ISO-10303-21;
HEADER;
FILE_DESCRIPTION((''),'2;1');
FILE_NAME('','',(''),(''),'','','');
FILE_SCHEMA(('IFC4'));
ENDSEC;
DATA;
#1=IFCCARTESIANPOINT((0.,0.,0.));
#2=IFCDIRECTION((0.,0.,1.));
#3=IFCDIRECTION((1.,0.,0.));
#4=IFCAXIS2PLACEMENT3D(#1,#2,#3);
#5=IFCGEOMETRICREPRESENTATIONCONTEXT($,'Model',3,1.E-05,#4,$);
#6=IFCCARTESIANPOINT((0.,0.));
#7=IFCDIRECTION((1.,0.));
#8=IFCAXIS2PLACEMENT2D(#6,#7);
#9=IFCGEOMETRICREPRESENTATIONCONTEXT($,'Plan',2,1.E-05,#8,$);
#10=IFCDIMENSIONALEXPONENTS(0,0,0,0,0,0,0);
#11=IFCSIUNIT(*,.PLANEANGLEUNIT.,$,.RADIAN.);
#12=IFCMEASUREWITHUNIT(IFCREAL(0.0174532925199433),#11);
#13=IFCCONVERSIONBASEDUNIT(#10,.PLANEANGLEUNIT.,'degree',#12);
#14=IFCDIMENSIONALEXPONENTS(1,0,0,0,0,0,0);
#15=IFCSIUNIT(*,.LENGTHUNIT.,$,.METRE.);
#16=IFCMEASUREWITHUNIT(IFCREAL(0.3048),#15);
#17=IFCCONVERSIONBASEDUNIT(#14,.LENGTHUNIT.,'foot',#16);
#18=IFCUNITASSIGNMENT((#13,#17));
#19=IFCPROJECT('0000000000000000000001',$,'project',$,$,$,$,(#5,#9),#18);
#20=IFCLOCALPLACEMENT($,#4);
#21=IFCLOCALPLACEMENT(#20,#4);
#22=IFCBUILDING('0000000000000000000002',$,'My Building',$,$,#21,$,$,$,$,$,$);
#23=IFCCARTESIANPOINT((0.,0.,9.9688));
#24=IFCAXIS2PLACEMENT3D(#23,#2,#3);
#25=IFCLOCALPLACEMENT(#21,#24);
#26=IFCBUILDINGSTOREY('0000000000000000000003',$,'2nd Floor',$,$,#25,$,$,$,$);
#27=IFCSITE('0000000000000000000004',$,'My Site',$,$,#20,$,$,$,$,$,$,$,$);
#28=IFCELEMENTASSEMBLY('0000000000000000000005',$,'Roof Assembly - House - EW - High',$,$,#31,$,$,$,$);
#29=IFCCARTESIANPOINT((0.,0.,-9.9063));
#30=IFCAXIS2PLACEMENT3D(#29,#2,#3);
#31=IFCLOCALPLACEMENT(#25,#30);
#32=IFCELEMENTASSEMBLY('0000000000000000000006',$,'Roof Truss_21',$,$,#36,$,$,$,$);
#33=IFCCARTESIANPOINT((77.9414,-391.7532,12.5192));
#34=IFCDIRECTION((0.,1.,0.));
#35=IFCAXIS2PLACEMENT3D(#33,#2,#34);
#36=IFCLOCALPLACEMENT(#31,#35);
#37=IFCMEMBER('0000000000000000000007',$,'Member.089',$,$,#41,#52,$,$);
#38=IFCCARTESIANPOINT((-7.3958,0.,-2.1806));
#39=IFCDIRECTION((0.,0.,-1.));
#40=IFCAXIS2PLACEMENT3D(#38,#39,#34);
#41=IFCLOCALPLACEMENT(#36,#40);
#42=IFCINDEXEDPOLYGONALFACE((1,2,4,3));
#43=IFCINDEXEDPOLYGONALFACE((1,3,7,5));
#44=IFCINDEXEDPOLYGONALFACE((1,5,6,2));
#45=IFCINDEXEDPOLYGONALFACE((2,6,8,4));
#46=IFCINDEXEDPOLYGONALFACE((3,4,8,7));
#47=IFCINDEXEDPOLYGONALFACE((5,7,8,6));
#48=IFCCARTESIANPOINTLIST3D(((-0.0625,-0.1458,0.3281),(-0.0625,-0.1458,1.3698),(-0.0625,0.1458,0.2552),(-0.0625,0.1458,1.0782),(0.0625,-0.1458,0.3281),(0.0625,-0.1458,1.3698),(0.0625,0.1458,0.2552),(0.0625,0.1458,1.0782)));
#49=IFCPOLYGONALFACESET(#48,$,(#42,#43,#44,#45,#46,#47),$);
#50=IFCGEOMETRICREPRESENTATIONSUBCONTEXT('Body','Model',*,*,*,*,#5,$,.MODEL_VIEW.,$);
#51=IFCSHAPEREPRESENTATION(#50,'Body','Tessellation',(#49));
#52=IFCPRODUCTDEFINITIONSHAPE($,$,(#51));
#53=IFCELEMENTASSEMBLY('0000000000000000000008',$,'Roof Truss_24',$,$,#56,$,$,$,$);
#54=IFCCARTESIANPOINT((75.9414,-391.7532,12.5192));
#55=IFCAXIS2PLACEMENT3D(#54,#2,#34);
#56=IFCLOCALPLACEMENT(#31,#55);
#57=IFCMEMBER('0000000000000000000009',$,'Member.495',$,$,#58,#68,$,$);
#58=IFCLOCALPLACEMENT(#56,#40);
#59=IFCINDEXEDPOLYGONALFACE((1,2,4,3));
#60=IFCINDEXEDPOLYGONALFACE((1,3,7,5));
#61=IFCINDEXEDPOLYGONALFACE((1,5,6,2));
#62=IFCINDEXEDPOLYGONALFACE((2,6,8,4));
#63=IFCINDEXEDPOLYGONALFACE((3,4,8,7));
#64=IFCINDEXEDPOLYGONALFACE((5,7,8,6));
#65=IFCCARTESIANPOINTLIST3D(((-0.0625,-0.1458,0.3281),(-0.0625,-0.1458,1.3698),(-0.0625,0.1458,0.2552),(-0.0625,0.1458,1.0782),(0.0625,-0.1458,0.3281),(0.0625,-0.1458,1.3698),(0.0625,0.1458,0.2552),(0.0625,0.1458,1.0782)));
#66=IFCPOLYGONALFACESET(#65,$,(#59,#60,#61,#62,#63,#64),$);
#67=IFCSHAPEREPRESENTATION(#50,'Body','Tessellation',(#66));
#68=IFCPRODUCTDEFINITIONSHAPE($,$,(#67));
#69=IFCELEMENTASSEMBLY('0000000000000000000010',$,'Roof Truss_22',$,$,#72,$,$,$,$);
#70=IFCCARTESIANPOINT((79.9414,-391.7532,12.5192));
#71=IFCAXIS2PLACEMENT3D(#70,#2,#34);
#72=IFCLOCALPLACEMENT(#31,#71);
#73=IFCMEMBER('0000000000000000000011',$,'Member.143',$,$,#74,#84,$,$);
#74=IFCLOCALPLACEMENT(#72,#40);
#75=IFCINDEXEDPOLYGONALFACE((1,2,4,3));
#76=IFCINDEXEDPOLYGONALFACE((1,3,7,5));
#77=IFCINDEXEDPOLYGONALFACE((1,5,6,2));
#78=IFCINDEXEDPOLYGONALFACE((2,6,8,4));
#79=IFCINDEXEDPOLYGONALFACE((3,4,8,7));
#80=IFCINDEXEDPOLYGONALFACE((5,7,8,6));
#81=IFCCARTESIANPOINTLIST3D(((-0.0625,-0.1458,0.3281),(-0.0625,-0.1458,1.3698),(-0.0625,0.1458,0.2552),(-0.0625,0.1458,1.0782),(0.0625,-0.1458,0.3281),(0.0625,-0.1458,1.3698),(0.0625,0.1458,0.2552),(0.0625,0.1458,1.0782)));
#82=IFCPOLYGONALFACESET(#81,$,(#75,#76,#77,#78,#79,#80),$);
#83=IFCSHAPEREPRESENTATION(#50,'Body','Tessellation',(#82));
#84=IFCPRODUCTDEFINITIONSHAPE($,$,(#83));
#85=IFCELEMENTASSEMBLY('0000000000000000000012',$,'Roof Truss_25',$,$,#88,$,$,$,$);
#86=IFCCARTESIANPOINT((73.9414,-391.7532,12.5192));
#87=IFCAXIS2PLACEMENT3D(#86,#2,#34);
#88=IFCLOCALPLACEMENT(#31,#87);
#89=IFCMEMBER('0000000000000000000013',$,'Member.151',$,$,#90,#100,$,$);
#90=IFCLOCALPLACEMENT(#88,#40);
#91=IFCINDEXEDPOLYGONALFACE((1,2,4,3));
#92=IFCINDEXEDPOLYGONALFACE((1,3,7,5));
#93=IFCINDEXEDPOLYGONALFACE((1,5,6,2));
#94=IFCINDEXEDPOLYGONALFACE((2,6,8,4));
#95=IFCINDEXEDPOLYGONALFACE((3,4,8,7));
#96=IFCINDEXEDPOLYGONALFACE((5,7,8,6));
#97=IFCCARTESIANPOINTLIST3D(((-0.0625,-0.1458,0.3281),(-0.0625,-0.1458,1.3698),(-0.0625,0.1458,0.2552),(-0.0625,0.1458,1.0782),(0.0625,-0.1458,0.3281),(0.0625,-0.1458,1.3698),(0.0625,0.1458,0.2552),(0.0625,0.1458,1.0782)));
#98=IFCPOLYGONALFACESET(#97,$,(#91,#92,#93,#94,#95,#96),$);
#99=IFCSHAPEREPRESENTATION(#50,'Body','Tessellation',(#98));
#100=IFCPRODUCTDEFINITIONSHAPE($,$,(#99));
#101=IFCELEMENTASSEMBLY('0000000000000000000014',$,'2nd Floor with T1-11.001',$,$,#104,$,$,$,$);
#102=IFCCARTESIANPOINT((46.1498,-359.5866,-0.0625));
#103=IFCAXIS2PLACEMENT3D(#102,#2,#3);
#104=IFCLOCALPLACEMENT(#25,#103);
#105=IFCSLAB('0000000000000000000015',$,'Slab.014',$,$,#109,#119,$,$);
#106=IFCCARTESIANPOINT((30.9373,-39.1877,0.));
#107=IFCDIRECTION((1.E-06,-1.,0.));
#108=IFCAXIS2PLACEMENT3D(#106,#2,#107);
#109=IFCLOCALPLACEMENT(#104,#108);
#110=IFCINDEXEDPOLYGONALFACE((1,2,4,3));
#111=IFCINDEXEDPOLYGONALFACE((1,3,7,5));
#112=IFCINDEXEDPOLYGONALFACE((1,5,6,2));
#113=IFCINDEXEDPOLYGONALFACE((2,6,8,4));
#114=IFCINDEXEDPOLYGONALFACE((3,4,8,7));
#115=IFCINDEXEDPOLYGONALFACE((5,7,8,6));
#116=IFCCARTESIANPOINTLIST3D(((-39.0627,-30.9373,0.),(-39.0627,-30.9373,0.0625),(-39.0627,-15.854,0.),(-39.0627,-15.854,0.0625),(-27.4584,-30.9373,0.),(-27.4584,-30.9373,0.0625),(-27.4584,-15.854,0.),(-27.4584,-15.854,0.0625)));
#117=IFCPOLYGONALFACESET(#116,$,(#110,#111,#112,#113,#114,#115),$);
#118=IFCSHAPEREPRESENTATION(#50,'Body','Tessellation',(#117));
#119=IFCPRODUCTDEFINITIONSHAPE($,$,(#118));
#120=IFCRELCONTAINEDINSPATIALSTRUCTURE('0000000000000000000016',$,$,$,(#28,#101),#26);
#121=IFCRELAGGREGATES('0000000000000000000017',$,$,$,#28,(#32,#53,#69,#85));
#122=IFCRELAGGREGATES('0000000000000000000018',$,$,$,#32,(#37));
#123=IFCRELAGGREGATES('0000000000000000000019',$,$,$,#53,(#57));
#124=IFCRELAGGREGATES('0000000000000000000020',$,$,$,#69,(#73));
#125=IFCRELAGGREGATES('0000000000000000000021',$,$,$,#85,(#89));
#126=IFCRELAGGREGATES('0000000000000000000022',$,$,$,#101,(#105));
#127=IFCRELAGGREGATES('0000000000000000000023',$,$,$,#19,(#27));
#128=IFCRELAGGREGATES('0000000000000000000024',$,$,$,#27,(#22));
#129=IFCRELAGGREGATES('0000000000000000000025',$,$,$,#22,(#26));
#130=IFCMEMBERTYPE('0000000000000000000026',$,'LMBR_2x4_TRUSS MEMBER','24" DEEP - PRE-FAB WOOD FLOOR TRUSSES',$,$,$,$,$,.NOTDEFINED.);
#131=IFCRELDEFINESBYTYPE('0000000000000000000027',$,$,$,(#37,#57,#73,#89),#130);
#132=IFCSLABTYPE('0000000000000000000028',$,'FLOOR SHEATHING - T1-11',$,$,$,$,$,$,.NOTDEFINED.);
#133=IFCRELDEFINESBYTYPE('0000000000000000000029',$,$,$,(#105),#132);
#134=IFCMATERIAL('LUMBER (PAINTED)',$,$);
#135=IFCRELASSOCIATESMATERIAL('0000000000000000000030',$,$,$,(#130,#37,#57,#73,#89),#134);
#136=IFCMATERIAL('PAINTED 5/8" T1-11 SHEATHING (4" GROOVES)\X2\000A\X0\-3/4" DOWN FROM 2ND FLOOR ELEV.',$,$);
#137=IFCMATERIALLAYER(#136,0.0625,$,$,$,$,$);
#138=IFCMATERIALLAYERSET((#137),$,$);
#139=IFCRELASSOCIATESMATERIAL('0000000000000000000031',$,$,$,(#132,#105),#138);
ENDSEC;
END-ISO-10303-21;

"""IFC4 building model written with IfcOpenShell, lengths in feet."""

from ifc_helpers import new_model, entity, si_unit, converted_unit, frame, origin_with_axes, origin_2d_with_axis, place, context, subcontext, project, spatial, indexed_curve, outline, extrude, clip, halfspace, material, layer, layer_set, layer_usage, material_profile, profile_set, profile_usage, type_object, element, aggregate, save


model = new_model("IFC4")

# Units and contexts
model_context = context("Model", 3, precision=1e-05, world=origin_with_axes())
plan_context = context("Plan", 2, precision=1e-05, world=origin_2d_with_axis())
body_context = subcontext(model_context, "Body", "Model", "MODEL_VIEW")
ifc_project = project(units=[converted_unit("PLANEANGLEUNIT", "degree", entity("IfcReal", 0.0174532925199433), si_unit("PLANEANGLEUNIT", "RADIAN"), dimensions=[0, 0, 0, 0, 0, 0, 0]), converted_unit("LENGTHUNIT", "foot", entity("IfcReal", 0.3048), si_unit("LENGTHUNIT", "METRE"), dimensions=[1, 0, 0, 0, 0, 0, 0])], contexts=[model_context, plan_context])

# Site, building, storey
site_placement = place(None, origin_with_axes())
site = spatial("IfcSite", under=ifc_project, at=site_placement, Name="My Site")
building_placement = place(site_placement, origin_with_axes())
building = spatial("IfcBuilding", under=site, at=building_placement, Name="My Building")
storey_placement = place(building_placement, frame((0.0, 0.0, 9.9688), z_axis=(0.0, 0.0, 1.0), x_axis=(1.0, 0.0, 0.0)))
storey = spatial("IfcBuildingStorey", under=building, at=storey_placement, Name="2nd Floor")

# Element assemblies, members
assembly_1_placement = place(storey_placement, frame((0.0, 0.0, -9.9063), z_axis=(0.0, 0.0, 1.0), x_axis=(1.0, 0.0, 0.0)))
assembly_1 = element("IfcElementAssembly", 1, at=assembly_1_placement, inside=storey, Name="Roof Assembly - House - EW - High")
assembly_2_placement = place(assembly_1_placement, frame((77.9414, -391.7532, 12.5192), z_axis=(0.0, 0.0, 1.0), x_axis=(0.0, 1.0, 0.0)))
assembly_2 = element("IfcElementAssembly", 2, at=assembly_2_placement, Name="Roof Truss_21")
ifc_material_1 = material(Name="LUMBER (PAINTED)")
ifc_material_profile_1 = material_profile(ifc_material_1, outline(indexed_curve([(-0.0625, -0.1458), (0.0625, -0.1458), (0.0625, 0.1458), (-0.0625, 0.1458), (-0.0625, -0.1458)])))
ifc_profile_set_1 = profile_set([ifc_material_profile_1])
ifc_profile_usage_1 = profile_usage(ifc_profile_set_1)
member_type_1 = type_object("IfcMemberType", Name="LMBR_2x4_TRUSS MEMBER", Description="24\" DEEP - PRE-FAB WOOD FLOOR TRUSSES", PredefinedType="NOTDEFINED", material=ifc_profile_set_1)
member_1_placement = place(assembly_2_placement, frame((-7.3958, 0.0, -2.1806), z_axis=(0.0, 0.0, -1.0), x_axis=(0.0, 1.0, 0.0)))
member_1 = element("IfcMember", 3, at=member_1_placement, type_object=member_type_1, material=ifc_profile_usage_1, Name="Member.089", context=body_context, shape_type="Clipping", body=[
    clip(clip(extrude(outline(indexed_curve([(-0.0625, -0.1458), (0.0625, -0.1458), (0.0625, 0.1458), (-0.0625, 0.1458), (-0.0625, -0.1458)])), origin_with_axes(), (0.0, 0.0, 1.0), 1.3698), halfspace(frame((0.0, 7.5424, -1.5944), z_axis=(0.0, -0.242599, -0.970127), x_axis=(-1.0, 0.000001, 0.0)), False)), halfspace(frame((397.5032, -0.1458, 1.3698), z_axis=(0.0, 0.707107, 0.707107), x_axis=(1.0, 0.0, 0.0)), False)),
])
assembly_3_placement = place(assembly_1_placement, frame((75.9414, -391.7532, 12.5192), z_axis=(0.0, 0.0, 1.0), x_axis=(0.0, 1.0, 0.0)))
assembly_3 = element("IfcElementAssembly", 4, at=assembly_3_placement, Name="Roof Truss_24")
ifc_profile_usage_2 = profile_usage(ifc_profile_set_1)
member_2_placement = place(assembly_3_placement, frame((-7.3958, 0.0, -2.1806), z_axis=(0.0, 0.0, -1.0), x_axis=(0.0, 1.0, 0.0)))
member_2 = element("IfcMember", 5, at=member_2_placement, type_object=member_type_1, material=ifc_profile_usage_2, Name="Member.495", context=body_context, shape_type="Clipping", body=[
    clip(clip(extrude(outline(indexed_curve([(-0.0625, -0.1458), (0.0625, -0.1458), (0.0625, 0.1458), (-0.0625, 0.1458), (-0.0625, -0.1458)])), origin_with_axes(), (0.0, 0.0, 1.0), 1.3698), halfspace(frame((0.0, 7.5424, -1.5944), z_axis=(0.0, -0.242599, -0.970127), x_axis=(-1.0, 0.000001, 0.0)), False)), halfspace(frame((397.5032, -0.1458, 1.3698), z_axis=(0.0, 0.707107, 0.707107), x_axis=(1.0, 0.0, 0.0)), False)),
])
assembly_4_placement = place(assembly_1_placement, frame((79.9414, -391.7532, 12.5192), z_axis=(0.0, 0.0, 1.0), x_axis=(0.0, 1.0, 0.0)))
assembly_4 = element("IfcElementAssembly", 6, at=assembly_4_placement, Name="Roof Truss_22")
ifc_profile_usage_3 = profile_usage(ifc_profile_set_1)
member_3_placement = place(assembly_4_placement, frame((-7.3958, 0.0, -2.1806), z_axis=(0.0, 0.0, -1.0), x_axis=(0.0, 1.0, 0.0)))
member_3 = element("IfcMember", 7, at=member_3_placement, type_object=member_type_1, material=ifc_profile_usage_3, Name="Member.143", context=body_context, shape_type="Clipping", body=[
    clip(clip(extrude(outline(indexed_curve([(-0.0625, -0.1458), (0.0625, -0.1458), (0.0625, 0.1458), (-0.0625, 0.1458), (-0.0625, -0.1458)])), origin_with_axes(), (0.0, 0.0, 1.0), 1.3698), halfspace(frame((0.0, 7.5424, -1.5944), z_axis=(0.0, -0.242599, -0.970127), x_axis=(-1.0, 0.000001, 0.0)), False)), halfspace(frame((397.5032, -0.1458, 1.3698), z_axis=(0.0, 0.707107, 0.707107), x_axis=(1.0, 0.0, 0.0)), False)),
])
assembly_5_placement = place(assembly_1_placement, frame((73.9414, -391.7532, 12.5192), z_axis=(0.0, 0.0, 1.0), x_axis=(0.0, 1.0, 0.0)))
assembly_5 = element("IfcElementAssembly", 8, at=assembly_5_placement, Name="Roof Truss_25")
aggregate(assembly_1, [assembly_2, assembly_3, assembly_4, assembly_5])
ifc_profile_usage_4 = profile_usage(ifc_profile_set_1)
member_4_placement = place(assembly_5_placement, frame((-7.3958, 0.0, -2.1806), z_axis=(0.0, 0.0, -1.0), x_axis=(0.0, 1.0, 0.0)))
member_4 = element("IfcMember", 9, at=member_4_placement, type_object=member_type_1, material=ifc_profile_usage_4, Name="Member.151", context=body_context, shape_type="Clipping", body=[
    clip(clip(extrude(outline(indexed_curve([(-0.0625, -0.1458), (0.0625, -0.1458), (0.0625, 0.1458), (-0.0625, 0.1458), (-0.0625, -0.1458)])), origin_with_axes(), (0.0, 0.0, 1.0), 1.3698), halfspace(frame((0.0, 7.5424, -1.5944), z_axis=(0.0, -0.242599, -0.970127), x_axis=(-1.0, 0.000001, 0.0)), False)), halfspace(frame((397.5032, -0.1458, 1.3698), z_axis=(0.0, 0.707107, 0.707107), x_axis=(1.0, 0.0, 0.0)), False)),
])
aggregate(assembly_2, [member_1])
aggregate(assembly_3, [member_2])
aggregate(assembly_4, [member_3])
aggregate(assembly_5, [member_4])

# Element assembly, slab
assembly_6_placement = place(storey_placement, frame((46.1498, -359.5866, -0.0625), z_axis=(0.0, 0.0, 1.0), x_axis=(1.0, 0.0, 0.0)))
assembly_6 = element("IfcElementAssembly", 10, at=assembly_6_placement, inside=storey, Name="2nd Floor with T1-11.001")
ifc_material_2 = material(Name="PAINTED 5/8\" T1-11 SHEATHING (4\" GROOVES)\n-3/4\" DOWN FROM 2ND FLOOR ELEV.")
ifc_layer = layer(ifc_material_2, 0.0625)
ifc_layer_set = layer_set([ifc_layer])
ifc_layer_usage = layer_usage(ifc_layer_set, "AXIS3", "POSITIVE", 0.0)
slab_type = type_object("IfcSlabType", Name="FLOOR SHEATHING - T1-11", PredefinedType="NOTDEFINED", material=ifc_layer_set)
slab_placement = place(assembly_6_placement, frame((30.9373, -39.1877, 0.0), z_axis=(0.0, 0.0, 1.0), x_axis=(0.000001, -1.0, 0.0)))
slab = element("IfcSlab", 11, at=slab_placement, type_object=slab_type, material=ifc_layer_usage, Name="Slab.014", context=body_context, shape_type="SweptSolid", body=[
    extrude(outline(indexed_curve([(-39.0627, -30.9373), (-27.4584, -30.9373), (-27.4584, -15.854), (-39.0627, -15.854), (-39.0627, -30.9373)])), None, (0.0, 0.0, 1.0), 0.0625),
])
aggregate(assembly_6, [slab])

save(model, "model.ifc")
